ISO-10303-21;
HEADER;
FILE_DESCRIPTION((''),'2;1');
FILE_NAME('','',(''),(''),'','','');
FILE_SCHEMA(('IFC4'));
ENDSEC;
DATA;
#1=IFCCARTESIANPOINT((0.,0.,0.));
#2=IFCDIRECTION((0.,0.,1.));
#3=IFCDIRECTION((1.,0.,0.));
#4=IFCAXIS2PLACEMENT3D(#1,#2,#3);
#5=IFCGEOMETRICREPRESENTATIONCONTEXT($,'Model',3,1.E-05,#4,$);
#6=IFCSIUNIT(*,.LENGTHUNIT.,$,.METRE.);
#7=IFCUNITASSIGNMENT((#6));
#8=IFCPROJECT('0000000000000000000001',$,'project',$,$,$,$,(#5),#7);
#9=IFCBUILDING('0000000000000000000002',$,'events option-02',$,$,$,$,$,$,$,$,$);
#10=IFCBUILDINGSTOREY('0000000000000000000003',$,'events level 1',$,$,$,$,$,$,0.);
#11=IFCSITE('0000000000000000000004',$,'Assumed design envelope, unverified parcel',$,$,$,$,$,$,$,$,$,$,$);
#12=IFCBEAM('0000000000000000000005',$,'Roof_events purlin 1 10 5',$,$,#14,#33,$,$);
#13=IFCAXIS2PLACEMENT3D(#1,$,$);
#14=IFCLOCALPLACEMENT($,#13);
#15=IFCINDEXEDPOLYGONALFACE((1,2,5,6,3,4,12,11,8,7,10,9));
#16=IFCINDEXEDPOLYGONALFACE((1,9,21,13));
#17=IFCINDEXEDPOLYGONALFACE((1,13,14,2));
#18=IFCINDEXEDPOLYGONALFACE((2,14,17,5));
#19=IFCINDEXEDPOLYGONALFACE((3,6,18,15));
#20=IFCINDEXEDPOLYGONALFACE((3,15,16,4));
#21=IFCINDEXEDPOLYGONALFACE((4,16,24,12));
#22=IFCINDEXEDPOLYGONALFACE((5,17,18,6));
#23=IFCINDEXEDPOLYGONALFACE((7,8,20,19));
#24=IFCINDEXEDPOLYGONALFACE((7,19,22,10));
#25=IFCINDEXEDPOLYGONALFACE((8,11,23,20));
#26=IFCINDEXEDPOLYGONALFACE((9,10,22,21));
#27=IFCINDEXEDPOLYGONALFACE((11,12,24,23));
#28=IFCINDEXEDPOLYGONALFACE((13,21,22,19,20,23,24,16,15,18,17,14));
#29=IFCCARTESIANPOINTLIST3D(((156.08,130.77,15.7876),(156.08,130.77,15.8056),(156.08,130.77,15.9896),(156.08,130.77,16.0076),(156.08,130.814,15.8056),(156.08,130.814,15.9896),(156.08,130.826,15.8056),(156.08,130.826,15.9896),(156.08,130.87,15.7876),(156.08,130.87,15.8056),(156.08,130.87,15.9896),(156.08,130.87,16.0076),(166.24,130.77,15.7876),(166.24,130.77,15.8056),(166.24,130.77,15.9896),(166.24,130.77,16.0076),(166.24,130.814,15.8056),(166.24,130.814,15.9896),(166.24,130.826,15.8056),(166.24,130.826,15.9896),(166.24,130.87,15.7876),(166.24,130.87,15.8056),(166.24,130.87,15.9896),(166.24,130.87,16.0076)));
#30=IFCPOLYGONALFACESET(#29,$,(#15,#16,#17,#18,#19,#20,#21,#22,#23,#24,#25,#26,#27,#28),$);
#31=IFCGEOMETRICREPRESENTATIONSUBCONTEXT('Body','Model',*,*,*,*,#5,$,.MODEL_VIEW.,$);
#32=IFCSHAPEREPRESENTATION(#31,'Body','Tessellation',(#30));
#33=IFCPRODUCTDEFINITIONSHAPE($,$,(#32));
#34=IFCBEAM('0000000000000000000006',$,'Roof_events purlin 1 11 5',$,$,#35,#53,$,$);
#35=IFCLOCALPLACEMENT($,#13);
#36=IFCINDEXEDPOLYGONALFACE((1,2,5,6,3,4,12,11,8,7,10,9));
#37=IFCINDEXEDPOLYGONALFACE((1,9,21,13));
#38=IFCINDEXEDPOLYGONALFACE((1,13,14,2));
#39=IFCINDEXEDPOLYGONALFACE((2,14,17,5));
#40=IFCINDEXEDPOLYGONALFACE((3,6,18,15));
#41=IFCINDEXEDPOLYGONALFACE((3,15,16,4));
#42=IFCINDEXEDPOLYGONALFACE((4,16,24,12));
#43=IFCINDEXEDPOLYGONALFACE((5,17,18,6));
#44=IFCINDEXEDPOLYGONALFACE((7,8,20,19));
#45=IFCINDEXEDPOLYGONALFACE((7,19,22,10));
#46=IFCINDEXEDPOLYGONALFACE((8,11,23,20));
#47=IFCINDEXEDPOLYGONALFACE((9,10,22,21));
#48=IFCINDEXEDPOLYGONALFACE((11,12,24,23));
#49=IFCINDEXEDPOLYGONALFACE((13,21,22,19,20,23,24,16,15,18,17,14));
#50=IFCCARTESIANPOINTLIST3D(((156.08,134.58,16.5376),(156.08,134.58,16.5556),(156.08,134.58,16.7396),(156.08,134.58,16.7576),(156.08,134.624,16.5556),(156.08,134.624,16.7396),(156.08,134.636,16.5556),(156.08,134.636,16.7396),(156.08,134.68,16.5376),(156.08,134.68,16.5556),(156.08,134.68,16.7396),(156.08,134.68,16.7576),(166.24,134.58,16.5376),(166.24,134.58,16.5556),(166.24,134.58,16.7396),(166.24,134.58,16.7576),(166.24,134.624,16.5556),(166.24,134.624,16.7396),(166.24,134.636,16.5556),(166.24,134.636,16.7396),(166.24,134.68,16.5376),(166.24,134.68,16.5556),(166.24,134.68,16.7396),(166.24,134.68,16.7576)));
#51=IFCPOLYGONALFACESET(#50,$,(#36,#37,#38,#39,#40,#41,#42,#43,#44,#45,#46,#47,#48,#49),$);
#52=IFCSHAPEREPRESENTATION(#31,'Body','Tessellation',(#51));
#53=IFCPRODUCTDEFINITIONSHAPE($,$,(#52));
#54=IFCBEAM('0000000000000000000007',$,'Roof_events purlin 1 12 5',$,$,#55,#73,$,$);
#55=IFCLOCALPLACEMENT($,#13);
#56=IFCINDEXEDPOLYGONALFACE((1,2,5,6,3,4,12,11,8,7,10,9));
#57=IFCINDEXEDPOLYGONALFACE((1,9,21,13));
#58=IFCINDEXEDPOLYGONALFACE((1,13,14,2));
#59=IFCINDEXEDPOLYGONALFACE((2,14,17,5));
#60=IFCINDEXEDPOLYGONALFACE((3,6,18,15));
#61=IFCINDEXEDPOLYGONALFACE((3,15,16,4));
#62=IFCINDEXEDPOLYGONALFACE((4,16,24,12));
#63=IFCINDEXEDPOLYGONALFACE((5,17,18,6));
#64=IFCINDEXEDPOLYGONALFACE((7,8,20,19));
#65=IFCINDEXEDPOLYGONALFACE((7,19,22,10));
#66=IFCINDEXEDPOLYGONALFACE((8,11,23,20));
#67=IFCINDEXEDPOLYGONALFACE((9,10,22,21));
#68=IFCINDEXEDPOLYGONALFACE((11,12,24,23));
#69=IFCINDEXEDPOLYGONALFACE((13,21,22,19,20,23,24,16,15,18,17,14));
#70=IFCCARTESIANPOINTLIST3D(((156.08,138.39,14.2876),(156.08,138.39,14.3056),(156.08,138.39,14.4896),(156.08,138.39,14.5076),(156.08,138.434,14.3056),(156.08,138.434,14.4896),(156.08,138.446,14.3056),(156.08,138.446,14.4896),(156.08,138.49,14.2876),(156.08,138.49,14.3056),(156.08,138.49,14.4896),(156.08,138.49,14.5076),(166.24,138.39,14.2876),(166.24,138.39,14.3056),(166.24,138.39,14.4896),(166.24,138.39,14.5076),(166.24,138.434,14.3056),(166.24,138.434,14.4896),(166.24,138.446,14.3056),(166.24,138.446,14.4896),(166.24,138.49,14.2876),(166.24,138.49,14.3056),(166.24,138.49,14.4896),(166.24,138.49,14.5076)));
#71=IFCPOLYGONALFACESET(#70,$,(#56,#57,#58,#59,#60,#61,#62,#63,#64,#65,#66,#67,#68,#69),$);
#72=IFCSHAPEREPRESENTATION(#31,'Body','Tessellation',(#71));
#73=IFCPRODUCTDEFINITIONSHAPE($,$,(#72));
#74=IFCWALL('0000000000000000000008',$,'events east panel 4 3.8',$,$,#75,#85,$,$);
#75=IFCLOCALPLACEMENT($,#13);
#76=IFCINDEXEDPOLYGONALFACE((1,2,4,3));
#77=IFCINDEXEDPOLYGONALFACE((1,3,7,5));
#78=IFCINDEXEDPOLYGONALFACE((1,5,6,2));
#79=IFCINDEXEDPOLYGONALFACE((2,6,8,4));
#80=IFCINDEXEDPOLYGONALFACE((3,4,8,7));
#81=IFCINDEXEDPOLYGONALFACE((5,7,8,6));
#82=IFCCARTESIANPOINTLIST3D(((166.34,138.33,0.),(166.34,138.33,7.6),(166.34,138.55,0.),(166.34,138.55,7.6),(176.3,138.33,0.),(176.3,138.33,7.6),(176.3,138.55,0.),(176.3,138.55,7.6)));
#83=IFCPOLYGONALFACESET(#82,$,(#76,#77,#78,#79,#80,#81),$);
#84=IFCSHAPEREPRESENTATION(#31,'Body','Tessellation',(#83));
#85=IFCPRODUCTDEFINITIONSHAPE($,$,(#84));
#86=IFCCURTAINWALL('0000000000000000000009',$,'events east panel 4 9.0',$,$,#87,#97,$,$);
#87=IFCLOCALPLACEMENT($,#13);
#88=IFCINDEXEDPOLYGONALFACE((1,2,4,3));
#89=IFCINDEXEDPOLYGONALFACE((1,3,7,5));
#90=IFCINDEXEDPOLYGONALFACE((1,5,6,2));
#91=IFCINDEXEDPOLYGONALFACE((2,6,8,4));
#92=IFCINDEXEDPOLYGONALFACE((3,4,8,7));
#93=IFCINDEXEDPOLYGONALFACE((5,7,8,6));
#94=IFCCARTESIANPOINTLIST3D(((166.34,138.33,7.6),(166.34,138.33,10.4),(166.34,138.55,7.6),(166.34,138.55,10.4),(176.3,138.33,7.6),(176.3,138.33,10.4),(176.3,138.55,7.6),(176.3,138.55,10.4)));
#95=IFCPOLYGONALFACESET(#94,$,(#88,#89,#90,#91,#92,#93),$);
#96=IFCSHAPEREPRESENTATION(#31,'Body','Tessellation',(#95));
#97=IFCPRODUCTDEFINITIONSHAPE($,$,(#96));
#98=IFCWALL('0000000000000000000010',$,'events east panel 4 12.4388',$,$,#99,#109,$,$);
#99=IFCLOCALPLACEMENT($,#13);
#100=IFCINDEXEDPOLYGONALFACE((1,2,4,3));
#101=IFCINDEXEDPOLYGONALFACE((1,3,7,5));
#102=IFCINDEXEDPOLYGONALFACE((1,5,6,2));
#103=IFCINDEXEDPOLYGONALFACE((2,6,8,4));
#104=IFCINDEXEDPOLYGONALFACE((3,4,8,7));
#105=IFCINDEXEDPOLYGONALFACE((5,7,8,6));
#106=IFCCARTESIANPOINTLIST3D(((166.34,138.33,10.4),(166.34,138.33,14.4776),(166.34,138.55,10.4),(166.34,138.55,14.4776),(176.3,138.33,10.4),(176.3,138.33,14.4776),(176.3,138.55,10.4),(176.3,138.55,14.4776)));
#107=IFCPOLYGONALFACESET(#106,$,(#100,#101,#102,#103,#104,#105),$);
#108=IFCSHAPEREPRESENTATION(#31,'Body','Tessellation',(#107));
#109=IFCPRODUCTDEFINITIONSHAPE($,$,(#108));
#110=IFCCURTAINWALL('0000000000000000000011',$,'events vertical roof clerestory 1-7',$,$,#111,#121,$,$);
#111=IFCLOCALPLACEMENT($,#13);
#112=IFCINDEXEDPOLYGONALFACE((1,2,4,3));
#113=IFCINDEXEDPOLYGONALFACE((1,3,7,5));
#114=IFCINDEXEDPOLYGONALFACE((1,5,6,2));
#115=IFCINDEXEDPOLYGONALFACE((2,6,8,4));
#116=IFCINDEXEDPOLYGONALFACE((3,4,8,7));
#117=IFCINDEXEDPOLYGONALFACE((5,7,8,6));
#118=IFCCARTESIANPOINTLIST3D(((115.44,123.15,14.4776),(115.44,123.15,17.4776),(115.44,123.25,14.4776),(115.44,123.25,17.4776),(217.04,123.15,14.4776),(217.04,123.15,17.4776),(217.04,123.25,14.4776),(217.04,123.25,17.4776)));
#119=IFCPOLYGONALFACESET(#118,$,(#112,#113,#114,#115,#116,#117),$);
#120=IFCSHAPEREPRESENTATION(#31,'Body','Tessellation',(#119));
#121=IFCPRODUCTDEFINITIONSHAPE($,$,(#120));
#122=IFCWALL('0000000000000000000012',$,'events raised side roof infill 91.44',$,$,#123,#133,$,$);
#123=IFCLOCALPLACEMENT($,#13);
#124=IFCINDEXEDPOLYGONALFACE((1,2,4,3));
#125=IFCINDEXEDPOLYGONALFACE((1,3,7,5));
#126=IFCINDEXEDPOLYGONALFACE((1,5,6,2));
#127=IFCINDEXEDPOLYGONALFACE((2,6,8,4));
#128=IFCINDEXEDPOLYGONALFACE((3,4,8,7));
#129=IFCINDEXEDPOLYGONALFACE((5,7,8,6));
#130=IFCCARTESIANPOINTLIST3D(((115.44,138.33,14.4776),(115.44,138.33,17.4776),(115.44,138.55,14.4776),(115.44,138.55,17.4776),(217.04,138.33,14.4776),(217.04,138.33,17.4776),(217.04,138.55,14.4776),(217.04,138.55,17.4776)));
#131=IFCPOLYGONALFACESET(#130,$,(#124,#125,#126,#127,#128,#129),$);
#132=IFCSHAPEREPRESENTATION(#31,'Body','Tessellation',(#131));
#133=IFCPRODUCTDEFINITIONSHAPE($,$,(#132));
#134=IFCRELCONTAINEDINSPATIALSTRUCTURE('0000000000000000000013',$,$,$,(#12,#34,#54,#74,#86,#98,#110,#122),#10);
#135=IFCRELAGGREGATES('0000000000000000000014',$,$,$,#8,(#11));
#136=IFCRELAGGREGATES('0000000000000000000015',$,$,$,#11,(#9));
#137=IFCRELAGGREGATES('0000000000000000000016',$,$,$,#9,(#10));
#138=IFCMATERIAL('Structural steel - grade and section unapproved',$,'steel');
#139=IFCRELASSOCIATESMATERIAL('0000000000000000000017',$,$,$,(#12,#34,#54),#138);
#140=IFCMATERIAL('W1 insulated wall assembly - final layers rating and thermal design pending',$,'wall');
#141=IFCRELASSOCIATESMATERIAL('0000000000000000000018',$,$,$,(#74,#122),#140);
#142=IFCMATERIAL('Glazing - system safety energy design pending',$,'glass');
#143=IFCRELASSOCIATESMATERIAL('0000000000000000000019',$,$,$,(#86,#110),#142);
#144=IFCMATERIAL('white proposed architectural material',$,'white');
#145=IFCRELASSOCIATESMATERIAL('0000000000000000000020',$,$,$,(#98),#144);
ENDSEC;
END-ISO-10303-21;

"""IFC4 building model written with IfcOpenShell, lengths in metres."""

from ifc_helpers import new_model, si_unit, frame, origin_with_axes, place, context, subcontext, project, spatial, rectangle, i_section, extrude, material, element, save


model = new_model("IFC4")

# Units and contexts
model_context = context("Model", 3, precision=1e-05, world=origin_with_axes())
body_context = subcontext(model_context, "Body", "Model", "MODEL_VIEW")
ifc_project = project(units=[si_unit("LENGTHUNIT", "METRE")], contexts=[model_context])

# Site, building, storey
site = spatial("IfcSite", under=ifc_project, Name="Assumed design envelope, unverified parcel")
building = spatial("IfcBuilding", under=site, Name="events option-02")
storey = spatial("IfcBuildingStorey", under=building, Name="events level 1", Elevation=0.0)

# Beams
ifc_material_1 = material(Name="Structural steel - grade and section unapproved", Category="steel")
for number, where, z_axis, x_axis, name in (
    (1, (166.24, 130.82, 15.8976), (-1.0, 0.0, 0.0), (0.0, -1.0, 0.0), "Roof_events purlin 1 10 5"),
    (2, (166.24, 134.63, 16.6476), (-1.0, 0.0, 0.0), (0.0, -1.0, 0.0), "Roof_events purlin 1 11 5"),
    (3, (166.24, 138.44, 14.3976), (-1.0, 0.0, 0.0), (0.0, -1.0, 0.0), "Roof_events purlin 1 12 5"),
):
    element("IfcBeam", number, at=place(None, frame(where, z_axis=z_axis, x_axis=x_axis)), inside=storey, material=ifc_material_1, Name=name, context=body_context, shape_type="SweptSolid", body=[
        extrude(i_section(OverallWidth=0.1, OverallDepth=0.22, WebThickness=0.012, FlangeThickness=0.018, FilletRadius=0.0), origin_with_axes(), (0.0, 0.0, 1.0), 10.16),
    ])

# Wall
ifc_material_2 = material(Name="W1 insulated wall assembly - final layers rating and thermal design pending", Category="wall")
wall_1_placement = place(None, frame((171.32, 138.44, 0.0), z_axis=(0.0, 0.0, 1.0), x_axis=(0.0, 1.0, 0.0)))
element("IfcWall", 4, at=wall_1_placement, inside=storey, material=ifc_material_2, Name="events east panel 4 3.8", context=body_context, shape_type="SweptSolid", body=[
    extrude(rectangle(XDim=0.22, YDim=9.96), origin_with_axes(), (0.0, 0.0, 1.0), 7.6),
])

# Curtain wall
ifc_material_3 = material(Name="Glazing - system safety energy design pending", Category="glass")
curtain_wall_1_placement = place(None, frame((171.32, 138.44, 7.6), z_axis=(0.0, 0.0, 1.0), x_axis=(0.0, 1.0, 0.0)))
element("IfcCurtainWall", 5, at=curtain_wall_1_placement, inside=storey, material=ifc_material_3, Name="events east panel 4 9.0", context=body_context, shape_type="SweptSolid", body=[
    extrude(rectangle(XDim=0.22, YDim=9.96), origin_with_axes(), (0.0, 0.0, 1.0), 2.8),
])

# Wall
ifc_material_4 = material(Name="white proposed architectural material", Category="white")
wall_2_placement = place(None, frame((171.32, 138.44, 10.4), z_axis=(0.0, 0.0, 1.0), x_axis=(0.0, 1.0, 0.0)))
element("IfcWall", 6, at=wall_2_placement, inside=storey, material=ifc_material_4, Name="events east panel 4 12.4388", context=body_context, shape_type="SweptSolid", body=[
    extrude(rectangle(XDim=0.22, YDim=9.96), origin_with_axes(), (0.0, 0.0, 1.0), 4.0776),
])

# Curtain wall
curtain_wall_2_placement = place(None, frame((166.24, 123.2, 14.4776), z_axis=(0.0, 0.0, 1.0), x_axis=(0.0, 1.0, 0.0)))
element("IfcCurtainWall", 7, at=curtain_wall_2_placement, inside=storey, material=ifc_material_3, Name="events vertical roof clerestory 1-7", context=body_context, shape_type="SweptSolid", body=[
    extrude(rectangle(XDim=0.1, YDim=101.6), origin_with_axes(), (0.0, 0.0, 1.0), 3.0),
])

# Wall
wall_3_placement = place(None, frame((166.24, 138.44, 14.4776), z_axis=(0.0, 0.0, 1.0), x_axis=(0.0, 1.0, 0.0)))
element("IfcWall", 8, at=wall_3_placement, inside=storey, material=ifc_material_2, Name="events raised side roof infill 91.44", context=body_context, shape_type="SweptSolid", body=[
    extrude(rectangle(XDim=0.22, YDim=101.6), origin_with_axes(), (0.0, 0.0, 1.0), 3.0),
])

save(model, "model.ifc")
